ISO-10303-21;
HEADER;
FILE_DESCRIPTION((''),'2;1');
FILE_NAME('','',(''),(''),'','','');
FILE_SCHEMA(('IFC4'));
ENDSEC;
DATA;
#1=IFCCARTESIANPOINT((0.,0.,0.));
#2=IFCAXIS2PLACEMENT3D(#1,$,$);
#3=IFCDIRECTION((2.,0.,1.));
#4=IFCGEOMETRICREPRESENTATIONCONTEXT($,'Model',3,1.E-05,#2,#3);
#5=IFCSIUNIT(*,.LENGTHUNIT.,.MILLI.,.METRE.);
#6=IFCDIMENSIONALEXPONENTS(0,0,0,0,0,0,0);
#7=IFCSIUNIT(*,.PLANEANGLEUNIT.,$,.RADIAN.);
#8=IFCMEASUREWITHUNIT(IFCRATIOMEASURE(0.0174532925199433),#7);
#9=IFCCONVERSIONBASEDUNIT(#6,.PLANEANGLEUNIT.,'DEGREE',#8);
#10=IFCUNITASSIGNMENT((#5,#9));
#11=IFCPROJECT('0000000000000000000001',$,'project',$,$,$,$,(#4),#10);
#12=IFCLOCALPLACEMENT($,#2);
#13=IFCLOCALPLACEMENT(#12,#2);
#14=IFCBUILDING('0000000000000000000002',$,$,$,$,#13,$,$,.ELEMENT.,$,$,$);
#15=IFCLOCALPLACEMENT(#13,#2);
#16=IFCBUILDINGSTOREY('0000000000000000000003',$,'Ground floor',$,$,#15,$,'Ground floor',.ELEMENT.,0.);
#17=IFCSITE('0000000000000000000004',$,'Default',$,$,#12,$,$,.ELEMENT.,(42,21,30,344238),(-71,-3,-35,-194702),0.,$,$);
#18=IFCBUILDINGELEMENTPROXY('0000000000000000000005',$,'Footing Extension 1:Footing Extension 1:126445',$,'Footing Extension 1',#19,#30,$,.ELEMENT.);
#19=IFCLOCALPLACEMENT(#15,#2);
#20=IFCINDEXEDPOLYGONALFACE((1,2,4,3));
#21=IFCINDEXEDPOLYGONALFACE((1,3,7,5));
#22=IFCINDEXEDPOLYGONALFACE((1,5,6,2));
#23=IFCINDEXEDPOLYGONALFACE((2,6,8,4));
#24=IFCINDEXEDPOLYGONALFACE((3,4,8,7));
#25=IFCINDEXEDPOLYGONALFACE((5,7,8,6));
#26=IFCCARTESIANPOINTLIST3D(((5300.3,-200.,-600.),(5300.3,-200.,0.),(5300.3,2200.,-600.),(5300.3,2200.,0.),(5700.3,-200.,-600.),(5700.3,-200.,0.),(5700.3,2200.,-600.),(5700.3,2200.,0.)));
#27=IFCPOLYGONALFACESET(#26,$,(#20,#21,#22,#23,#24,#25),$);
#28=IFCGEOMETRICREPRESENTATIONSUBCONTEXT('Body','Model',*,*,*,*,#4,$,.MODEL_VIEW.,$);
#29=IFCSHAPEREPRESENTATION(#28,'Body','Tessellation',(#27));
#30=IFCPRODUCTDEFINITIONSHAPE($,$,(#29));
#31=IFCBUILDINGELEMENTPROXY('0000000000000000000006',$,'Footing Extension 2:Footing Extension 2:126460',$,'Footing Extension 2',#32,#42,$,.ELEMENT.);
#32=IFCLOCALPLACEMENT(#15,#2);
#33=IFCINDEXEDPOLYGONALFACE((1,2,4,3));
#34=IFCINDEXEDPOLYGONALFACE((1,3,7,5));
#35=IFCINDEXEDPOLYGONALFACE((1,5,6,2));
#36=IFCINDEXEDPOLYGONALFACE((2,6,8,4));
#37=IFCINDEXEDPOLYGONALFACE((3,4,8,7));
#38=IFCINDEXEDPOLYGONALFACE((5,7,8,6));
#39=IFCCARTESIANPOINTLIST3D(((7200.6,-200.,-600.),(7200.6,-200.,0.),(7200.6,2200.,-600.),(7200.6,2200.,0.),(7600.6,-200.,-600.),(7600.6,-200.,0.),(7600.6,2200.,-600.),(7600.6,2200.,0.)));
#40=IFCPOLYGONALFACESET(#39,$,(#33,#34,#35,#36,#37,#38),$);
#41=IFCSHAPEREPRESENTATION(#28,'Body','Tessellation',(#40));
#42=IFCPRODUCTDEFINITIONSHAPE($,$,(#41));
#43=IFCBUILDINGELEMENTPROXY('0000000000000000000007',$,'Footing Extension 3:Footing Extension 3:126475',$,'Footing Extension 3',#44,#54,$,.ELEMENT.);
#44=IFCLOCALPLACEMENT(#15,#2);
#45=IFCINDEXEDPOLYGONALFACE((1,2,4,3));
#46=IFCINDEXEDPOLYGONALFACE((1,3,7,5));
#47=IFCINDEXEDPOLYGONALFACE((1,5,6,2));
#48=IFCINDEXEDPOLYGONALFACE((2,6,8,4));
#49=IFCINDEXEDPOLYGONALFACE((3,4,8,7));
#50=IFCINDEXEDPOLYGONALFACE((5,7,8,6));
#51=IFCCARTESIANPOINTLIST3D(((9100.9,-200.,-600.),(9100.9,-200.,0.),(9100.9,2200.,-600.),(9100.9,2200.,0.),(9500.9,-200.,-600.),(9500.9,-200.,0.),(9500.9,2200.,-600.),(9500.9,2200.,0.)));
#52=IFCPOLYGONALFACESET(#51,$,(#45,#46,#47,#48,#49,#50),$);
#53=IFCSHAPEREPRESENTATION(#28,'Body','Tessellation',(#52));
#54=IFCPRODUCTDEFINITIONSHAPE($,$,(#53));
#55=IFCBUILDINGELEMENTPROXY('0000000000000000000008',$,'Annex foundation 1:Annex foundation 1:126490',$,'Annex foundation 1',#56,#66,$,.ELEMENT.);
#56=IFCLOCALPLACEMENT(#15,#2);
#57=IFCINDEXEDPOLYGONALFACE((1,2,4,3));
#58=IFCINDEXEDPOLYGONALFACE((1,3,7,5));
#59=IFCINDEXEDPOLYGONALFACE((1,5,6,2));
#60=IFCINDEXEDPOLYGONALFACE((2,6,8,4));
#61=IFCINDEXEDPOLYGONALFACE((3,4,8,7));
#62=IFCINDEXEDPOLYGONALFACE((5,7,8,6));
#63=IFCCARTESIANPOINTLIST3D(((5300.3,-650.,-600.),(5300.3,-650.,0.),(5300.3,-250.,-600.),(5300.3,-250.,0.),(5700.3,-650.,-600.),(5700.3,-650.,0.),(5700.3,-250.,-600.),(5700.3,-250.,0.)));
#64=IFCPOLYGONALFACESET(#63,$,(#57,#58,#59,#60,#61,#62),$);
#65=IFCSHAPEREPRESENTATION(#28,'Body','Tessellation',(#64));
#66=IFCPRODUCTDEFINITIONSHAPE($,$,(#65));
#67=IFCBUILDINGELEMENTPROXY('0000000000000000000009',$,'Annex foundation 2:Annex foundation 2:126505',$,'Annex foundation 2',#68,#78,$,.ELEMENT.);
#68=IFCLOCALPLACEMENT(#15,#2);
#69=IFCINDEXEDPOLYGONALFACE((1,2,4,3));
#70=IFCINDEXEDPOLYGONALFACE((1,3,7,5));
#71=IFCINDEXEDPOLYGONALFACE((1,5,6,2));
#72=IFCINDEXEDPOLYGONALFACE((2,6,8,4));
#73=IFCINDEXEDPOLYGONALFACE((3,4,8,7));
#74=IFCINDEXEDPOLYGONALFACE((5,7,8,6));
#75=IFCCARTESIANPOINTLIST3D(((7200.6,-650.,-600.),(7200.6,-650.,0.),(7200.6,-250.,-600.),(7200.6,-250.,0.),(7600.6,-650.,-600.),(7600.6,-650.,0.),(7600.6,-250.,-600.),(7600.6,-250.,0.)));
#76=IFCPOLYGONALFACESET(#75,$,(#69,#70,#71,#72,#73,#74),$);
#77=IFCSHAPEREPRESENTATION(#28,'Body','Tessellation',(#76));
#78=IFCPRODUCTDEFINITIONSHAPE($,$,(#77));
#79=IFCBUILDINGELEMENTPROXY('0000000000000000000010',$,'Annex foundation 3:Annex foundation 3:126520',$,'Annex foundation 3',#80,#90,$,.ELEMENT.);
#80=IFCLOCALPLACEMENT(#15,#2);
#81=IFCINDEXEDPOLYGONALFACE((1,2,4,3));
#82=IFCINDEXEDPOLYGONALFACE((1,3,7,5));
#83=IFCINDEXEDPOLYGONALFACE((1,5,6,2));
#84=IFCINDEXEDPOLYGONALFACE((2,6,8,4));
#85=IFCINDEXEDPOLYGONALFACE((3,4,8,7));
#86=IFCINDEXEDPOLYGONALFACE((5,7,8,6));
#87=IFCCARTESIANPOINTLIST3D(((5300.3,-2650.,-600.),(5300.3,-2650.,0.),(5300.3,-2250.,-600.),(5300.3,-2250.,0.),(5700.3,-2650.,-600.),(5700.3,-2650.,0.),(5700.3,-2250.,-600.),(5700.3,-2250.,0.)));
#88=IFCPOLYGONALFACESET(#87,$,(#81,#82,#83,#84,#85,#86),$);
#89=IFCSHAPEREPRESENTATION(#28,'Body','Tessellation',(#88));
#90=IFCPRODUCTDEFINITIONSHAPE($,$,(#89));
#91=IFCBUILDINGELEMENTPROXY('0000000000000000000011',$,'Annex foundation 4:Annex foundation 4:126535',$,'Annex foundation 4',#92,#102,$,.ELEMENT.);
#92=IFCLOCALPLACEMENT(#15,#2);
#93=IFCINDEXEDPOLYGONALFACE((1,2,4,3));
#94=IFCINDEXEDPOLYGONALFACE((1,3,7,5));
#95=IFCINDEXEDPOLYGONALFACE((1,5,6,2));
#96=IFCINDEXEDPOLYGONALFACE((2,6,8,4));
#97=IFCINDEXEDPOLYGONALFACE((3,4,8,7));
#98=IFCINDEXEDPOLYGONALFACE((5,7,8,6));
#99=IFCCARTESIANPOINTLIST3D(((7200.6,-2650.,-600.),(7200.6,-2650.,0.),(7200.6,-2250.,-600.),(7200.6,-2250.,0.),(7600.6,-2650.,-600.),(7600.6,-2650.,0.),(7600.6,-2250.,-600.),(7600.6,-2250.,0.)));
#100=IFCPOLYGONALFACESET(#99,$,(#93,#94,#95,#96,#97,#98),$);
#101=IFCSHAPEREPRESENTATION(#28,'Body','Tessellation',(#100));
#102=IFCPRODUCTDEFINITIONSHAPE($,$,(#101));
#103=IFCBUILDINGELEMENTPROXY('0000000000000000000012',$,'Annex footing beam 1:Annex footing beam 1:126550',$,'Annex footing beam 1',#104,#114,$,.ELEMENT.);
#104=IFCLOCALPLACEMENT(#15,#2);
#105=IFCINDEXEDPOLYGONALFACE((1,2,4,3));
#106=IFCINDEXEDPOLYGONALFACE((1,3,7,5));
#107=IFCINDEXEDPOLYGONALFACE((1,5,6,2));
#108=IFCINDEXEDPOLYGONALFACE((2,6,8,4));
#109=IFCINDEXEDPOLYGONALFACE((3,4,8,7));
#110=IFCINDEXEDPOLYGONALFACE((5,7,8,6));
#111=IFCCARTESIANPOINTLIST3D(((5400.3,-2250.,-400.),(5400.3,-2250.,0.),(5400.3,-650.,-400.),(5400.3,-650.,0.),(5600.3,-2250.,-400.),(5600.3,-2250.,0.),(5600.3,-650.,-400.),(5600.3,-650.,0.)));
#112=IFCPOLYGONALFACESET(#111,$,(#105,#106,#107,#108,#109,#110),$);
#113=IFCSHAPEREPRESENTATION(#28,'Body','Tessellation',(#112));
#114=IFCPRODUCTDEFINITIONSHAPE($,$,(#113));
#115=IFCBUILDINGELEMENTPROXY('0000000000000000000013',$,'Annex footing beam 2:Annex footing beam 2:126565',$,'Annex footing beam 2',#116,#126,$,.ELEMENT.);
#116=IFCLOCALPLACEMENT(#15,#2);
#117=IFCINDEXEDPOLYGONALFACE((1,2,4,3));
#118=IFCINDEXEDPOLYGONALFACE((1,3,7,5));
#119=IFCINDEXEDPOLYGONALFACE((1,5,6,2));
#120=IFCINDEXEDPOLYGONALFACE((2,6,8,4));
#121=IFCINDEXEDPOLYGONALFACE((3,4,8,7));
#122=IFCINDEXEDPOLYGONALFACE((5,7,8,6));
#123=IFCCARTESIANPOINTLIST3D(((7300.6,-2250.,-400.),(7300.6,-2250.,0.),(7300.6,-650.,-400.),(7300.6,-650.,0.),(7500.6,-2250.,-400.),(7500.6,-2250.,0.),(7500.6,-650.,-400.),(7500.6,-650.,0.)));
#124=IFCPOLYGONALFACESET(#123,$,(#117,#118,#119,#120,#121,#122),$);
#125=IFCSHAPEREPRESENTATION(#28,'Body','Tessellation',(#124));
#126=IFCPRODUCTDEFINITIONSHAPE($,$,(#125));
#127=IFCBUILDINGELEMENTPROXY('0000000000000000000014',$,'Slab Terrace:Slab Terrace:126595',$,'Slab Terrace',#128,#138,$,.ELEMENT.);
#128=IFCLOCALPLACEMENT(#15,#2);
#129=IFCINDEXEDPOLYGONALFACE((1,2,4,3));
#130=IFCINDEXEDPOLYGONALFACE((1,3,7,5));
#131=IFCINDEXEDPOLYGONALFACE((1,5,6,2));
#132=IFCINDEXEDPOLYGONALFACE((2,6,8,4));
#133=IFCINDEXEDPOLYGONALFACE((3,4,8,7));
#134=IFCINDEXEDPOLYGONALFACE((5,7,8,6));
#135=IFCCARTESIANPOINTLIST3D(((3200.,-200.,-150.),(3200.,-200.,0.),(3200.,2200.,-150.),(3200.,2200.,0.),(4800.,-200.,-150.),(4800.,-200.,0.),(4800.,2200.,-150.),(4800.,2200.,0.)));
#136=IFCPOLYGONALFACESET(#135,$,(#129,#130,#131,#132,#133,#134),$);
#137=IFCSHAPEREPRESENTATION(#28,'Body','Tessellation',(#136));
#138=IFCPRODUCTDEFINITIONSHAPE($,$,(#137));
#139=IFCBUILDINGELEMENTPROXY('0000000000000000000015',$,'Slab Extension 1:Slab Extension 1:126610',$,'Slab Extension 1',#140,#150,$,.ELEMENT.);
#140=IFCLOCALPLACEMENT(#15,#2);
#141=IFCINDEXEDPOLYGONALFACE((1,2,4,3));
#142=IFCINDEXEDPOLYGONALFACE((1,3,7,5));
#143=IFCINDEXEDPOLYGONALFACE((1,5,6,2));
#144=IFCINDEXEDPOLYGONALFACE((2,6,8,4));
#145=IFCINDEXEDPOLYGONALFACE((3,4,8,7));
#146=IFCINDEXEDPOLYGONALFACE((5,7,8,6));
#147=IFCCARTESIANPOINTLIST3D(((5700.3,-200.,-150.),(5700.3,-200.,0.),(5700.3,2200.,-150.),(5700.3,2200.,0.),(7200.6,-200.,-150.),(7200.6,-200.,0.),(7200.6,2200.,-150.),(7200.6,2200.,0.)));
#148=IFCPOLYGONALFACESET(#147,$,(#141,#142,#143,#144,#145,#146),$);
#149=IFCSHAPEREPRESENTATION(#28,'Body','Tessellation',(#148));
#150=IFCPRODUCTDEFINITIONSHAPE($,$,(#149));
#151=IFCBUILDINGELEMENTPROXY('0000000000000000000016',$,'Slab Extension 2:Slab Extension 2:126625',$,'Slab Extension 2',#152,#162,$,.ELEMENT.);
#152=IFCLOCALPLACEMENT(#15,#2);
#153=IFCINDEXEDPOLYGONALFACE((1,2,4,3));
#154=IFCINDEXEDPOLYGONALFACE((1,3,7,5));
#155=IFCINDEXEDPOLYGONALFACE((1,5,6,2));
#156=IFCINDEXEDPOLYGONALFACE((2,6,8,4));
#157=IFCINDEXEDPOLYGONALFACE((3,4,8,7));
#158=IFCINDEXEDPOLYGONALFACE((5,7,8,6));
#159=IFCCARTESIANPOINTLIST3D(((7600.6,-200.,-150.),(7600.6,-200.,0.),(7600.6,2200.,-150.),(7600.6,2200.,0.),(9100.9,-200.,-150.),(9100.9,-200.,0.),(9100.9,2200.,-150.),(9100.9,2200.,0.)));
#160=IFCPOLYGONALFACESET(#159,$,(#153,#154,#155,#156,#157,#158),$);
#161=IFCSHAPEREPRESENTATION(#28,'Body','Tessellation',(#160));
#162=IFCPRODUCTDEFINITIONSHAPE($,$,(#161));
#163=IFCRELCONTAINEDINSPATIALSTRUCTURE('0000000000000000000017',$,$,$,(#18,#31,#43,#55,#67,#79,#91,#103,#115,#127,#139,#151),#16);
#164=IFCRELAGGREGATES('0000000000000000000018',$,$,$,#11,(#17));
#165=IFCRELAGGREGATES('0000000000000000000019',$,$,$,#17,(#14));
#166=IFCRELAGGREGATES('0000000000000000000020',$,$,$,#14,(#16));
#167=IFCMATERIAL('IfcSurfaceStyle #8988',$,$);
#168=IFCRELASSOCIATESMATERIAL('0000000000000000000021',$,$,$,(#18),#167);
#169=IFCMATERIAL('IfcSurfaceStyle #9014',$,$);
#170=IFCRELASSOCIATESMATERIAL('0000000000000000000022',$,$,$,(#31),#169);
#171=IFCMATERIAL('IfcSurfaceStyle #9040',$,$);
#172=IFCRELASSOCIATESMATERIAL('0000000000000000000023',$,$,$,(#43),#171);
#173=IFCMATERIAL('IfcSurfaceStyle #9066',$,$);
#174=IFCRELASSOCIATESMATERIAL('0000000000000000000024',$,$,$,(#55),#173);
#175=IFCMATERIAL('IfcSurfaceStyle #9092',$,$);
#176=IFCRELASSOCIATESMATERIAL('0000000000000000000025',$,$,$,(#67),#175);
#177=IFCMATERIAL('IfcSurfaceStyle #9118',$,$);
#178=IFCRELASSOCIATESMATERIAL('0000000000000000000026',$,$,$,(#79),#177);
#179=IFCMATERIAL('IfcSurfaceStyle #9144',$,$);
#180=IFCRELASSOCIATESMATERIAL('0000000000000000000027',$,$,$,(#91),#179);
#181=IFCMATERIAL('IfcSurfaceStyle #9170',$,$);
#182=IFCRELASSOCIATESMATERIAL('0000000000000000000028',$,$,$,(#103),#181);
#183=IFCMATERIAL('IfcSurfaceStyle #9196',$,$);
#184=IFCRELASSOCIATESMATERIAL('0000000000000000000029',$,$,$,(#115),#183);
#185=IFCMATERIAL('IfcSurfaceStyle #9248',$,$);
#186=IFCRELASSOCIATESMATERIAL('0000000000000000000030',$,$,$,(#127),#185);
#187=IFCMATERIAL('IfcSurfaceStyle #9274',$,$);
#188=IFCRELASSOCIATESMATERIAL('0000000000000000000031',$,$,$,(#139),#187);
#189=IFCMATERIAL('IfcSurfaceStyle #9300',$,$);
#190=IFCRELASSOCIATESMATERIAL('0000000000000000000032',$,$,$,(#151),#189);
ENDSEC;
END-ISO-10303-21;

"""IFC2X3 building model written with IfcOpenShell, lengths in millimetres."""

from ifc_helpers import new_model, entity, si_unit, converted_unit, direction, frame, frame_2d, origin, origin_2d_with_axis, place, context, subcontext, project, spatial, rectangle, extrude, source, transform, mapped, material, element, save


model = new_model("IFC2X3")

# Units and contexts
model_context = context("Model", 3, precision=1e-05, world=origin(), true_north=direction((2.0, 0.0, 1.0)))
body_context = subcontext(model_context, "Body", "Model", "MODEL_VIEW")
ifc_project = project(units=[si_unit("LENGTHUNIT", "METRE", prefix="MILLI"), converted_unit("PLANEANGLEUNIT", "DEGREE", entity("IfcRatioMeasure", 0.0174532925199433), si_unit("PLANEANGLEUNIT", "RADIAN"), dimensions=[0, 0, 0, 0, 0, 0, 0])], contexts=[model_context])

# Site, building, storey
site_placement = place(None, origin())
site = spatial("IfcSite", under=ifc_project, at=site_placement, Name="Default", CompositionType="ELEMENT", RefLatitude=(42, 21, 30, 344238), RefLongitude=(-71, -3, -35, -194702), RefElevation=0.0)
building_placement = place(site_placement, origin())
building = spatial("IfcBuilding", under=site, at=building_placement, CompositionType="ELEMENT")
storey_placement = place(building_placement, origin())
storey = spatial("IfcBuildingStorey", under=building, at=storey_placement, Name="Ground floor", LongName="Ground floor", CompositionType="ELEMENT", Elevation=0.0)

# Building element proxies
ifc_material_1 = material(Name="IfcSurfaceStyle #8988")
shared_shape_1 = source(origin(), body_context, "Body", "SweptSolid", [
    extrude(rectangle(XDim=2400.0, YDim=400.0, at=origin_2d_with_axis()), frame((200.0, 1200.0, 0.0), z_axis=(0.0, 0.0, 1.0), x_axis=(0.0, -1.0, 0.0)), (0.0, 0.0, 1.0), 600.0),
])
proxy_1_placement = place(building_placement, frame((5300.3, -200.0, -600.0)))
element("IfcBuildingElementProxy", 1, at=proxy_1_placement, inside=storey, material=ifc_material_1, Name="Footing Extension 1:Footing Extension 1:126445", ObjectType="Footing Extension 1", CompositionType="ELEMENT", context=body_context, shape_type="MappedRepresentation", body=[
    mapped(shared_shape_1, transform((0.0, 0.0, 0.0), scale=1.0)),
])
ifc_material_2 = material(Name="IfcSurfaceStyle #9014")
shared_shape_2 = source(origin(), body_context, "Body", "SweptSolid", [
    extrude(rectangle(XDim=2400.0, YDim=400.0, at=origin_2d_with_axis()), frame((200.0, 1200.0, 0.0), z_axis=(0.0, 0.0, 1.0), x_axis=(0.0, -1.0, 0.0)), (0.0, 0.0, 1.0), 600.0),
])
proxy_2_placement = place(building_placement, frame((7200.6, -200.0, -600.0)))
element("IfcBuildingElementProxy", 2, at=proxy_2_placement, inside=storey, material=ifc_material_2, Name="Footing Extension 2:Footing Extension 2:126460", ObjectType="Footing Extension 2", CompositionType="ELEMENT", context=body_context, shape_type="MappedRepresentation", body=[
    mapped(shared_shape_2, transform((0.0, 0.0, 0.0), scale=1.0)),
])
ifc_material_3 = material(Name="IfcSurfaceStyle #9040")
shared_shape_3 = source(origin(), body_context, "Body", "SweptSolid", [
    extrude(rectangle(XDim=2400.0, YDim=400.0, at=origin_2d_with_axis()), frame((200.0, 1200.0, 0.0), z_axis=(0.0, 0.0, 1.0), x_axis=(0.0, -1.0, 0.0)), (0.0, 0.0, 1.0), 600.0),
])
proxy_3_placement = place(building_placement, frame((9100.9, -200.0, -600.0)))
element("IfcBuildingElementProxy", 3, at=proxy_3_placement, inside=storey, material=ifc_material_3, Name="Footing Extension 3:Footing Extension 3:126475", ObjectType="Footing Extension 3", CompositionType="ELEMENT", context=body_context, shape_type="MappedRepresentation", body=[
    mapped(shared_shape_3, transform((0.0, 0.0, 0.0), scale=1.0)),
])
ifc_material_4 = material(Name="IfcSurfaceStyle #9066")
shared_shape_4 = source(origin(), body_context, "Body", "SweptSolid", [
    extrude(rectangle(XDim=400.0, YDim=400.0, at=origin_2d_with_axis()), frame((200.0, 200.0, 0.0), z_axis=(0.0, 0.0, 1.0), x_axis=(0.0, 1.0, 0.0)), (0.0, 0.0, 1.0), 600.0),
])
proxy_4_placement = place(building_placement, frame((5300.3, -650.0, -600.0)))
element("IfcBuildingElementProxy", 4, at=proxy_4_placement, inside=storey, material=ifc_material_4, Name="Annex foundation 1:Annex foundation 1:126490", ObjectType="Annex foundation 1", CompositionType="ELEMENT", context=body_context, shape_type="MappedRepresentation", body=[
    mapped(shared_shape_4, transform((0.0, 0.0, 0.0), scale=1.0)),
])
ifc_material_5 = material(Name="IfcSurfaceStyle #9092")
shared_shape_5 = source(origin(), body_context, "Body", "SweptSolid", [
    extrude(rectangle(XDim=400.0, YDim=400.0, at=origin_2d_with_axis()), frame((200.0, 200.0, 0.0), z_axis=(0.0, 0.0, 1.0), x_axis=(0.0, 1.0, 0.0)), (0.0, 0.0, 1.0), 600.0),
])
proxy_5_placement = place(building_placement, frame((7200.6, -650.0, -600.0)))
element("IfcBuildingElementProxy", 5, at=proxy_5_placement, inside=storey, material=ifc_material_5, Name="Annex foundation 2:Annex foundation 2:126505", ObjectType="Annex foundation 2", CompositionType="ELEMENT", context=body_context, shape_type="MappedRepresentation", body=[
    mapped(shared_shape_5, transform((0.0, 0.0, 0.0), scale=1.0)),
])
ifc_material_6 = material(Name="IfcSurfaceStyle #9118")
shared_shape_6 = source(origin(), body_context, "Body", "SweptSolid", [
    extrude(rectangle(XDim=400.0, YDim=400.0, at=origin_2d_with_axis()), frame((200.0, 200.0, 0.0), z_axis=(0.0, 0.0, 1.0), x_axis=(0.0, 1.0, 0.0)), (0.0, 0.0, 1.0), 600.0),
])
proxy_6_placement = place(building_placement, frame((5300.3, -2650.0, -600.0)))
element("IfcBuildingElementProxy", 6, at=proxy_6_placement, inside=storey, material=ifc_material_6, Name="Annex foundation 3:Annex foundation 3:126520", ObjectType="Annex foundation 3", CompositionType="ELEMENT", context=body_context, shape_type="MappedRepresentation", body=[
    mapped(shared_shape_6, transform((0.0, 0.0, 0.0), scale=1.0)),
])
ifc_material_7 = material(Name="IfcSurfaceStyle #9144")
shared_shape_7 = source(origin(), body_context, "Body", "SweptSolid", [
    extrude(rectangle(XDim=400.0, YDim=400.0, at=origin_2d_with_axis()), frame((200.0, 200.0, 0.0), z_axis=(0.0, 0.0, 1.0), x_axis=(0.0, 1.0, 0.0)), (0.0, 0.0, 1.0), 600.0),
])
proxy_7_placement = place(building_placement, frame((7200.6, -2650.0, -600.0)))
element("IfcBuildingElementProxy", 7, at=proxy_7_placement, inside=storey, material=ifc_material_7, Name="Annex foundation 4:Annex foundation 4:126535", ObjectType="Annex foundation 4", CompositionType="ELEMENT", context=body_context, shape_type="MappedRepresentation", body=[
    mapped(shared_shape_7, transform((0.0, 0.0, 0.0), scale=1.0)),
])
ifc_material_8 = material(Name="IfcSurfaceStyle #9170")
shared_shape_8 = source(origin(), body_context, "Body", "SweptSolid", [
    extrude(rectangle(XDim=1600.0, YDim=200.0, at=origin_2d_with_axis()), frame((100.0, 800.0, 0.0), z_axis=(0.0, 0.0, 1.0), x_axis=(0.0, -1.0, 0.0)), (0.0, 0.0, 1.0), 400.0),
])
proxy_8_placement = place(building_placement, frame((5400.3, -2250.0, -400.0)))
element("IfcBuildingElementProxy", 8, at=proxy_8_placement, inside=storey, material=ifc_material_8, Name="Annex footing beam 1:Annex footing beam 1:126550", ObjectType="Annex footing beam 1", CompositionType="ELEMENT", context=body_context, shape_type="MappedRepresentation", body=[
    mapped(shared_shape_8, transform((0.0, 0.0, 0.0), scale=1.0)),
])
ifc_material_9 = material(Name="IfcSurfaceStyle #9196")
shared_shape_9 = source(origin(), body_context, "Body", "SweptSolid", [
    extrude(rectangle(XDim=1600.0, YDim=200.0, at=origin_2d_with_axis()), frame((100.0, 800.0, 0.0), z_axis=(0.0, 0.0, 1.0), x_axis=(0.0, -1.0, 0.0)), (0.0, 0.0, 1.0), 400.0),
])
proxy_9_placement = place(building_placement, frame((7300.6, -2250.0, -400.0)))
element("IfcBuildingElementProxy", 9, at=proxy_9_placement, inside=storey, material=ifc_material_9, Name="Annex footing beam 2:Annex footing beam 2:126565", ObjectType="Annex footing beam 2", CompositionType="ELEMENT", context=body_context, shape_type="MappedRepresentation", body=[
    mapped(shared_shape_9, transform((0.0, 0.0, 0.0), scale=1.0)),
])
ifc_material_10 = material(Name="IfcSurfaceStyle #9248")
shared_shape_10 = source(origin(), body_context, "Body", "SweptSolid", [
    extrude(rectangle(XDim=1600.0, YDim=2400.0, at=origin_2d_with_axis()), frame((800.0, 1200.0, 0.0), z_axis=(0.0, 0.0, 1.0), x_axis=(-1.0, 0.0, 0.0)), (0.0, 0.0, 1.0), 150.0),
])
proxy_10_placement = place(building_placement, frame((3200.0, -200.0, -150.0)))
element("IfcBuildingElementProxy", 10, at=proxy_10_placement, inside=storey, material=ifc_material_10, Name="Slab Terrace:Slab Terrace:126595", ObjectType="Slab Terrace", CompositionType="ELEMENT", context=body_context, shape_type="MappedRepresentation", body=[
    mapped(shared_shape_10, transform((0.0, 0.0, 0.0), scale=1.0)),
])
ifc_material_11 = material(Name="IfcSurfaceStyle #9274")
shared_shape_11 = source(origin(), body_context, "Body", "SweptSolid", [
    extrude(rectangle(XDim=1500.3, YDim=2400.0, at=frame_2d((0.0, 0.0), x_axis=(1.0, 0.0))), frame((750.2, 1200.0, 0.0)), (0.0, 0.0, 1.0), 150.0),
])
proxy_11_placement = place(building_placement, frame((5700.3, -200.0, -150.0)))
element("IfcBuildingElementProxy", 11, at=proxy_11_placement, inside=storey, material=ifc_material_11, Name="Slab Extension 1:Slab Extension 1:126610", ObjectType="Slab Extension 1", CompositionType="ELEMENT", context=body_context, shape_type="MappedRepresentation", body=[
    mapped(shared_shape_11, transform((0.0, 0.0, 0.0), scale=1.0)),
])
ifc_material_12 = material(Name="IfcSurfaceStyle #9300")
shared_shape_12 = source(origin(), body_context, "Body", "SweptSolid", [
    extrude(rectangle(XDim=1500.3, YDim=2400.0, at=origin_2d_with_axis()), frame((750.1, 1200.0, 0.0)), (0.0, 0.0, 1.0), 150.0),
])
proxy_12_placement = place(building_placement, frame((7600.6, -200.0, -150.0)))
element("IfcBuildingElementProxy", 12, at=proxy_12_placement, inside=storey, material=ifc_material_12, Name="Slab Extension 2:Slab Extension 2:126625", ObjectType="Slab Extension 2", CompositionType="ELEMENT", context=body_context, shape_type="MappedRepresentation", body=[
    mapped(shared_shape_12, transform((0.0, 0.0, 0.0), scale=1.0)),
])

save(model, "model.ifc")
